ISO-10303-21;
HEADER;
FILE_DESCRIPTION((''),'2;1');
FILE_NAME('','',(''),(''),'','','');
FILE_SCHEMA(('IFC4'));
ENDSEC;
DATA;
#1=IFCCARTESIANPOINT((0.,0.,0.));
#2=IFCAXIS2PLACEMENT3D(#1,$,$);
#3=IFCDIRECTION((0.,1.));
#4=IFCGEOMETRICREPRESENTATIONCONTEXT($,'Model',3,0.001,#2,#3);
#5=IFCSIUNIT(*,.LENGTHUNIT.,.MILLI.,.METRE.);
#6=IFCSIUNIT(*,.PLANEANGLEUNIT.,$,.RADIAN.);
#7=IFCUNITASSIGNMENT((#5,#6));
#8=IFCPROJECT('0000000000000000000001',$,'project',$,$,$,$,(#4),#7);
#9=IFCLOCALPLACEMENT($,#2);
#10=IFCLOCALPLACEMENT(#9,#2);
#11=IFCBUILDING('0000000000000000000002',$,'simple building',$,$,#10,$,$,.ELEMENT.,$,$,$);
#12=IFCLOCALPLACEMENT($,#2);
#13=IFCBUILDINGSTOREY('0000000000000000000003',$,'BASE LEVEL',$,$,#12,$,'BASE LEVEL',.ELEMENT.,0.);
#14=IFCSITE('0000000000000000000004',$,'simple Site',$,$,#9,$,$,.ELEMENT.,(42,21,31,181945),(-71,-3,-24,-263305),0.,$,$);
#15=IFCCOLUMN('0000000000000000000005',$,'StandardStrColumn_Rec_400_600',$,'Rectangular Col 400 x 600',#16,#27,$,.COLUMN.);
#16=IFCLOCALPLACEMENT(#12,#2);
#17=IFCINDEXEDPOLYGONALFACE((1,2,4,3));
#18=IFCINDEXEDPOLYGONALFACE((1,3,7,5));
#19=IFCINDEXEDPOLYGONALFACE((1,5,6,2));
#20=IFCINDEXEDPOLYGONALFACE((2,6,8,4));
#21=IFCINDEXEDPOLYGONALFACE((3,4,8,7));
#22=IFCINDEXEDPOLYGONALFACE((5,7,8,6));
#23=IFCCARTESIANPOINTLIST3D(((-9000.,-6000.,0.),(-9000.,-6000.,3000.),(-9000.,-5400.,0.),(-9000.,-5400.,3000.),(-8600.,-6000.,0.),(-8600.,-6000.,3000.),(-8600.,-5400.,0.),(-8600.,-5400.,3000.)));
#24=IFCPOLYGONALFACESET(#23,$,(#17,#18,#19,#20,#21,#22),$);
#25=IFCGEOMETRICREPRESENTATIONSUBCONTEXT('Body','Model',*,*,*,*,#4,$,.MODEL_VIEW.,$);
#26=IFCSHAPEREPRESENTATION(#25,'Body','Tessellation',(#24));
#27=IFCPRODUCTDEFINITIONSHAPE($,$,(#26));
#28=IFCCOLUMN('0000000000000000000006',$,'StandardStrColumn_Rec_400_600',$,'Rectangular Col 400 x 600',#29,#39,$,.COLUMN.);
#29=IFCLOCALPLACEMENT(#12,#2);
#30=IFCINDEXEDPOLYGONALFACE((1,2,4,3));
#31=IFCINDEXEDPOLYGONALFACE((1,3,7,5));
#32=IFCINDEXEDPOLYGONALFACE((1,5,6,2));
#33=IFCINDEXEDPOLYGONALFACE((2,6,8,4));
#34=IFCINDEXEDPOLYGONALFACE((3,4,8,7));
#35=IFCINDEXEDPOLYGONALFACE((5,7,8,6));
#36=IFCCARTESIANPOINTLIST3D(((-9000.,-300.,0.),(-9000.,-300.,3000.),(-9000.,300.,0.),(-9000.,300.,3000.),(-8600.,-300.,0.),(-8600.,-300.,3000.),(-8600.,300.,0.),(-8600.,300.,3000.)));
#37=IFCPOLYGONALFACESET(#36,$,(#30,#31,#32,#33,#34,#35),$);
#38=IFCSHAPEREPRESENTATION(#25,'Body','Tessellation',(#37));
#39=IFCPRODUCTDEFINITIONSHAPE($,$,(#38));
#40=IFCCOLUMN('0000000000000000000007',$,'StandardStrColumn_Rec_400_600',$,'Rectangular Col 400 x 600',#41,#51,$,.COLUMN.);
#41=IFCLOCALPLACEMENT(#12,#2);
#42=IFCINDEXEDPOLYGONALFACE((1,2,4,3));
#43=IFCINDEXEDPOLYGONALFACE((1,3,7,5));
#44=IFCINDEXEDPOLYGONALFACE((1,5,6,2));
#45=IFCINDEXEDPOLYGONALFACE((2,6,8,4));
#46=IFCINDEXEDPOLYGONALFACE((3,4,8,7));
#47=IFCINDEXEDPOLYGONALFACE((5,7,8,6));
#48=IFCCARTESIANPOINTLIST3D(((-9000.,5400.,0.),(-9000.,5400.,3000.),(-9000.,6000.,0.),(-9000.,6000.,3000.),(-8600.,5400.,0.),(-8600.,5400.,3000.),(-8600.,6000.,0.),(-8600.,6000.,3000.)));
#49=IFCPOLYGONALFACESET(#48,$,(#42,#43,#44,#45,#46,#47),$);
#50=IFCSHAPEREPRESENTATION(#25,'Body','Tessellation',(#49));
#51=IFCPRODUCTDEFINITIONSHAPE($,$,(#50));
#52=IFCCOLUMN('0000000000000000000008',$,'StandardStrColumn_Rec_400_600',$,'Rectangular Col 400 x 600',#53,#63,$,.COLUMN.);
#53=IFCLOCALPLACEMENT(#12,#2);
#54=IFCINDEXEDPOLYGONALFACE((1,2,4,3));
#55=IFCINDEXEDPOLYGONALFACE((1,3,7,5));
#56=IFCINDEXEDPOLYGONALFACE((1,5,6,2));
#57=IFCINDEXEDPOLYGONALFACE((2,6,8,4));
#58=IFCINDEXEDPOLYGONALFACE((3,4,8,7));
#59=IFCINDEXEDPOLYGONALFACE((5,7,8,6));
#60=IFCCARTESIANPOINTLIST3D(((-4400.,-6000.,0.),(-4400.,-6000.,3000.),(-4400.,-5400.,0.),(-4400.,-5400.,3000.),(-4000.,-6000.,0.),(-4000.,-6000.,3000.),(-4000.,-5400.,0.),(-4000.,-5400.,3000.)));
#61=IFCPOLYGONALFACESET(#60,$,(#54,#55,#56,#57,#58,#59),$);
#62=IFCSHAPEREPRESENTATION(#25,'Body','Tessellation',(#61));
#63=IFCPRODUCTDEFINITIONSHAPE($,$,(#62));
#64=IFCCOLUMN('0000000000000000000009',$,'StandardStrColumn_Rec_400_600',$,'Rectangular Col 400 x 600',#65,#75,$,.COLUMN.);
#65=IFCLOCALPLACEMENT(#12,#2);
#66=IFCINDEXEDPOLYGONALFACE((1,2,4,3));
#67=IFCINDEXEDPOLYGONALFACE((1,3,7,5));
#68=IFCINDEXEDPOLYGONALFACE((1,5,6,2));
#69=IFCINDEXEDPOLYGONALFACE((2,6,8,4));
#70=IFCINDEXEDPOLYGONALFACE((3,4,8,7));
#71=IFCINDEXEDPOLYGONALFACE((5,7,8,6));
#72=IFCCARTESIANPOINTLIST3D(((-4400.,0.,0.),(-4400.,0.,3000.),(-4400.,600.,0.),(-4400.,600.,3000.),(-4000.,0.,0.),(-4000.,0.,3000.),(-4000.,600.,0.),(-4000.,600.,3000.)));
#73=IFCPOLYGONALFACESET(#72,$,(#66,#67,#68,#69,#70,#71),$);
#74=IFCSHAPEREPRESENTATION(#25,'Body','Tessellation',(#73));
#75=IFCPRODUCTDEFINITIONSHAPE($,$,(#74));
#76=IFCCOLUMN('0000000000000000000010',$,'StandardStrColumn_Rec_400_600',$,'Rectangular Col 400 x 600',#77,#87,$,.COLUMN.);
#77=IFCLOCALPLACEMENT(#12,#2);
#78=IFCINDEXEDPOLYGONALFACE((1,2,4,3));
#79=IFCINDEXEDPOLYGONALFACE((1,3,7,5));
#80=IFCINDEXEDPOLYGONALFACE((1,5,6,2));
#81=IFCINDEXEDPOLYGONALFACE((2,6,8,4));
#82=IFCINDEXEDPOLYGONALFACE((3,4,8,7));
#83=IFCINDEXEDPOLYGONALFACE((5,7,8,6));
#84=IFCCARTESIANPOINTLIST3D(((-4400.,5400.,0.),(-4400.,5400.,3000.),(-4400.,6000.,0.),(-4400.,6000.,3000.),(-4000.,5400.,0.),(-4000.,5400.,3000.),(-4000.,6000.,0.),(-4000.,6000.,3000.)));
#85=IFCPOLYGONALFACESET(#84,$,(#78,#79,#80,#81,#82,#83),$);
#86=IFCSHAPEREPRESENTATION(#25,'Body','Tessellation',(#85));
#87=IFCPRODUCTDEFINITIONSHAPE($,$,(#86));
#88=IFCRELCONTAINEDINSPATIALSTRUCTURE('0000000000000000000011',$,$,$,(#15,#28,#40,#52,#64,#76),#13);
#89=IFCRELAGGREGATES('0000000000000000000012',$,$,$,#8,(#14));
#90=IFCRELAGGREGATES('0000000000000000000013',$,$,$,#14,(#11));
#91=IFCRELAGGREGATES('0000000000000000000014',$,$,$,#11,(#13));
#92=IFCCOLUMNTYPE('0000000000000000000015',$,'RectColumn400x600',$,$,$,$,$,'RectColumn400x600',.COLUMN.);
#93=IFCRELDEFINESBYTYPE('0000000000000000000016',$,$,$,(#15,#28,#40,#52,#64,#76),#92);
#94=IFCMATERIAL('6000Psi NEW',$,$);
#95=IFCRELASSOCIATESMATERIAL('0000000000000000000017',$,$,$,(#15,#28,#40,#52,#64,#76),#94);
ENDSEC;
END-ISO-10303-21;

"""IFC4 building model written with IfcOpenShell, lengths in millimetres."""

from ifc_helpers import new_model, si_unit, direction, frame, origin, origin_with_axes, origin_2d_with_axis, place, context, subcontext, project, spatial, rectangle, extrude, material, material_profile, profile_set, profile_usage, type_object, element, save


model = new_model("IFC4")

# Units and contexts
model_context = context("Model", 3, precision=0.001, world=origin(), true_north=direction((0.0, 1.0)))
body_context = subcontext(model_context, "Body", "Model", "MODEL_VIEW")
ifc_project = project(units=[si_unit("LENGTHUNIT", "METRE", prefix="MILLI"), si_unit("PLANEANGLEUNIT", "RADIAN")], contexts=[model_context])

# Site, building, storey
site_placement = place(None, origin())
site = spatial("IfcSite", under=ifc_project, at=site_placement, Name="simple Site", CompositionType="ELEMENT", RefLatitude=(42, 21, 31, 181945), RefLongitude=(-71, -3, -24, -263305), RefElevation=0.0)
building_placement = place(site_placement, origin())
building = spatial("IfcBuilding", under=site, at=building_placement, Name="simple building", CompositionType="ELEMENT")
storey_placement = place(None, origin())
storey = spatial("IfcBuildingStorey", under=building, at=storey_placement, Name="BASE LEVEL", LongName="BASE LEVEL", CompositionType="ELEMENT", Elevation=0.0)

# Columns
ifc_material = material(Name="6000Psi NEW")
ifc_material_profile = material_profile(ifc_material, rectangle(XDim=400.0, YDim=600.0, at=origin_2d_with_axis()))
ifc_profile_set = profile_set([ifc_material_profile])
ifc_profile_usage_1 = profile_usage(ifc_profile_set, cardinal=7)
column_type = type_object("IfcColumnType", Name="RectColumn400x600", ElementType="RectColumn400x600", PredefinedType="COLUMN")
column_1_placement = place(None, frame((-8800.0, -5700.0, 0.0), z_axis=(0.0, 0.0, 1.0), x_axis=(1.0, 0.0, 0.0)))
element("IfcColumn", 1, at=column_1_placement, inside=storey, type_object=column_type, material=ifc_profile_usage_1, Name="StandardStrColumn_Rec_400_600", ObjectType="Rectangular Col 400 x 600", PredefinedType="COLUMN", context=body_context, shape_type="SweptSolid", body=[
    extrude(rectangle(XDim=400.0, YDim=600.0, at=origin_2d_with_axis()), origin_with_axes(), (0.0, 0.0, 1.0), 3000.0),
])
ifc_profile_usage_2 = profile_usage(ifc_profile_set, cardinal=4)
column_2_placement = place(None, frame((-8800.0, 0.0, 0.0), z_axis=(0.0, 0.0, 1.0), x_axis=(1.0, 0.0, 0.0)))
element("IfcColumn", 2, at=column_2_placement, inside=storey, type_object=column_type, material=ifc_profile_usage_2, Name="StandardStrColumn_Rec_400_600", ObjectType="Rectangular Col 400 x 600", PredefinedType="COLUMN", context=body_context, shape_type="SweptSolid", body=[
    extrude(rectangle(XDim=400.0, YDim=600.0, at=origin_2d_with_axis()), origin_with_axes(), (0.0, 0.0, 1.0), 3000.0),
])
ifc_profile_usage_3 = profile_usage(ifc_profile_set, cardinal=1)
column_3_placement = place(None, frame((-8800.0, 5700.0, 0.0), z_axis=(0.0, 0.0, 1.0), x_axis=(1.0, 0.0, 0.0)))
element("IfcColumn", 3, at=column_3_placement, inside=storey, type_object=column_type, material=ifc_profile_usage_3, Name="StandardStrColumn_Rec_400_600", ObjectType="Rectangular Col 400 x 600", PredefinedType="COLUMN", context=body_context, shape_type="SweptSolid", body=[
    extrude(rectangle(XDim=400.0, YDim=600.0, at=origin_2d_with_axis()), origin_with_axes(), (0.0, 0.0, 1.0), 3000.0),
])
ifc_profile_usage_4 = profile_usage(ifc_profile_set, cardinal=9)
for number, where, z_axis, x_axis, name in (
    (4, (-4200.0, -5700.0, 0.0), (0.0, 0.0, 1.0), (1.0, 0.0, 0.0), "StandardStrColumn_Rec_400_600"),
    (5, (-4200.0, 300.0, 0.0), (0.0, 0.0, 1.0), (1.0, 0.0, 0.0), "StandardStrColumn_Rec_400_600"),
):
    element("IfcColumn", number, at=place(None, frame(where, z_axis=z_axis, x_axis=x_axis)), inside=storey, type_object=column_type, material=ifc_profile_usage_4, Name=name, ObjectType="Rectangular Col 400 x 600", PredefinedType="COLUMN", context=body_context, shape_type="SweptSolid", body=[
        extrude(rectangle(XDim=400.0, YDim=600.0, at=origin_2d_with_axis()), origin_with_axes(), (0.0, 0.0, 1.0), 3000.0),
    ])
ifc_profile_usage_5 = profile_usage(ifc_profile_set, cardinal=3)
column_4_placement = place(None, frame((-4200.0, 5700.0, 0.0), z_axis=(0.0, 0.0, 1.0), x_axis=(1.0, 0.0, 0.0)))
element("IfcColumn", 6, at=column_4_placement, inside=storey, type_object=column_type, material=ifc_profile_usage_5, Name="StandardStrColumn_Rec_400_600", ObjectType="Rectangular Col 400 x 600", PredefinedType="COLUMN", context=body_context, shape_type="SweptSolid", body=[
    extrude(rectangle(XDim=400.0, YDim=600.0, at=origin_2d_with_axis()), origin_with_axes(), (0.0, 0.0, 1.0), 3000.0),
])

save(model, "model.ifc")
